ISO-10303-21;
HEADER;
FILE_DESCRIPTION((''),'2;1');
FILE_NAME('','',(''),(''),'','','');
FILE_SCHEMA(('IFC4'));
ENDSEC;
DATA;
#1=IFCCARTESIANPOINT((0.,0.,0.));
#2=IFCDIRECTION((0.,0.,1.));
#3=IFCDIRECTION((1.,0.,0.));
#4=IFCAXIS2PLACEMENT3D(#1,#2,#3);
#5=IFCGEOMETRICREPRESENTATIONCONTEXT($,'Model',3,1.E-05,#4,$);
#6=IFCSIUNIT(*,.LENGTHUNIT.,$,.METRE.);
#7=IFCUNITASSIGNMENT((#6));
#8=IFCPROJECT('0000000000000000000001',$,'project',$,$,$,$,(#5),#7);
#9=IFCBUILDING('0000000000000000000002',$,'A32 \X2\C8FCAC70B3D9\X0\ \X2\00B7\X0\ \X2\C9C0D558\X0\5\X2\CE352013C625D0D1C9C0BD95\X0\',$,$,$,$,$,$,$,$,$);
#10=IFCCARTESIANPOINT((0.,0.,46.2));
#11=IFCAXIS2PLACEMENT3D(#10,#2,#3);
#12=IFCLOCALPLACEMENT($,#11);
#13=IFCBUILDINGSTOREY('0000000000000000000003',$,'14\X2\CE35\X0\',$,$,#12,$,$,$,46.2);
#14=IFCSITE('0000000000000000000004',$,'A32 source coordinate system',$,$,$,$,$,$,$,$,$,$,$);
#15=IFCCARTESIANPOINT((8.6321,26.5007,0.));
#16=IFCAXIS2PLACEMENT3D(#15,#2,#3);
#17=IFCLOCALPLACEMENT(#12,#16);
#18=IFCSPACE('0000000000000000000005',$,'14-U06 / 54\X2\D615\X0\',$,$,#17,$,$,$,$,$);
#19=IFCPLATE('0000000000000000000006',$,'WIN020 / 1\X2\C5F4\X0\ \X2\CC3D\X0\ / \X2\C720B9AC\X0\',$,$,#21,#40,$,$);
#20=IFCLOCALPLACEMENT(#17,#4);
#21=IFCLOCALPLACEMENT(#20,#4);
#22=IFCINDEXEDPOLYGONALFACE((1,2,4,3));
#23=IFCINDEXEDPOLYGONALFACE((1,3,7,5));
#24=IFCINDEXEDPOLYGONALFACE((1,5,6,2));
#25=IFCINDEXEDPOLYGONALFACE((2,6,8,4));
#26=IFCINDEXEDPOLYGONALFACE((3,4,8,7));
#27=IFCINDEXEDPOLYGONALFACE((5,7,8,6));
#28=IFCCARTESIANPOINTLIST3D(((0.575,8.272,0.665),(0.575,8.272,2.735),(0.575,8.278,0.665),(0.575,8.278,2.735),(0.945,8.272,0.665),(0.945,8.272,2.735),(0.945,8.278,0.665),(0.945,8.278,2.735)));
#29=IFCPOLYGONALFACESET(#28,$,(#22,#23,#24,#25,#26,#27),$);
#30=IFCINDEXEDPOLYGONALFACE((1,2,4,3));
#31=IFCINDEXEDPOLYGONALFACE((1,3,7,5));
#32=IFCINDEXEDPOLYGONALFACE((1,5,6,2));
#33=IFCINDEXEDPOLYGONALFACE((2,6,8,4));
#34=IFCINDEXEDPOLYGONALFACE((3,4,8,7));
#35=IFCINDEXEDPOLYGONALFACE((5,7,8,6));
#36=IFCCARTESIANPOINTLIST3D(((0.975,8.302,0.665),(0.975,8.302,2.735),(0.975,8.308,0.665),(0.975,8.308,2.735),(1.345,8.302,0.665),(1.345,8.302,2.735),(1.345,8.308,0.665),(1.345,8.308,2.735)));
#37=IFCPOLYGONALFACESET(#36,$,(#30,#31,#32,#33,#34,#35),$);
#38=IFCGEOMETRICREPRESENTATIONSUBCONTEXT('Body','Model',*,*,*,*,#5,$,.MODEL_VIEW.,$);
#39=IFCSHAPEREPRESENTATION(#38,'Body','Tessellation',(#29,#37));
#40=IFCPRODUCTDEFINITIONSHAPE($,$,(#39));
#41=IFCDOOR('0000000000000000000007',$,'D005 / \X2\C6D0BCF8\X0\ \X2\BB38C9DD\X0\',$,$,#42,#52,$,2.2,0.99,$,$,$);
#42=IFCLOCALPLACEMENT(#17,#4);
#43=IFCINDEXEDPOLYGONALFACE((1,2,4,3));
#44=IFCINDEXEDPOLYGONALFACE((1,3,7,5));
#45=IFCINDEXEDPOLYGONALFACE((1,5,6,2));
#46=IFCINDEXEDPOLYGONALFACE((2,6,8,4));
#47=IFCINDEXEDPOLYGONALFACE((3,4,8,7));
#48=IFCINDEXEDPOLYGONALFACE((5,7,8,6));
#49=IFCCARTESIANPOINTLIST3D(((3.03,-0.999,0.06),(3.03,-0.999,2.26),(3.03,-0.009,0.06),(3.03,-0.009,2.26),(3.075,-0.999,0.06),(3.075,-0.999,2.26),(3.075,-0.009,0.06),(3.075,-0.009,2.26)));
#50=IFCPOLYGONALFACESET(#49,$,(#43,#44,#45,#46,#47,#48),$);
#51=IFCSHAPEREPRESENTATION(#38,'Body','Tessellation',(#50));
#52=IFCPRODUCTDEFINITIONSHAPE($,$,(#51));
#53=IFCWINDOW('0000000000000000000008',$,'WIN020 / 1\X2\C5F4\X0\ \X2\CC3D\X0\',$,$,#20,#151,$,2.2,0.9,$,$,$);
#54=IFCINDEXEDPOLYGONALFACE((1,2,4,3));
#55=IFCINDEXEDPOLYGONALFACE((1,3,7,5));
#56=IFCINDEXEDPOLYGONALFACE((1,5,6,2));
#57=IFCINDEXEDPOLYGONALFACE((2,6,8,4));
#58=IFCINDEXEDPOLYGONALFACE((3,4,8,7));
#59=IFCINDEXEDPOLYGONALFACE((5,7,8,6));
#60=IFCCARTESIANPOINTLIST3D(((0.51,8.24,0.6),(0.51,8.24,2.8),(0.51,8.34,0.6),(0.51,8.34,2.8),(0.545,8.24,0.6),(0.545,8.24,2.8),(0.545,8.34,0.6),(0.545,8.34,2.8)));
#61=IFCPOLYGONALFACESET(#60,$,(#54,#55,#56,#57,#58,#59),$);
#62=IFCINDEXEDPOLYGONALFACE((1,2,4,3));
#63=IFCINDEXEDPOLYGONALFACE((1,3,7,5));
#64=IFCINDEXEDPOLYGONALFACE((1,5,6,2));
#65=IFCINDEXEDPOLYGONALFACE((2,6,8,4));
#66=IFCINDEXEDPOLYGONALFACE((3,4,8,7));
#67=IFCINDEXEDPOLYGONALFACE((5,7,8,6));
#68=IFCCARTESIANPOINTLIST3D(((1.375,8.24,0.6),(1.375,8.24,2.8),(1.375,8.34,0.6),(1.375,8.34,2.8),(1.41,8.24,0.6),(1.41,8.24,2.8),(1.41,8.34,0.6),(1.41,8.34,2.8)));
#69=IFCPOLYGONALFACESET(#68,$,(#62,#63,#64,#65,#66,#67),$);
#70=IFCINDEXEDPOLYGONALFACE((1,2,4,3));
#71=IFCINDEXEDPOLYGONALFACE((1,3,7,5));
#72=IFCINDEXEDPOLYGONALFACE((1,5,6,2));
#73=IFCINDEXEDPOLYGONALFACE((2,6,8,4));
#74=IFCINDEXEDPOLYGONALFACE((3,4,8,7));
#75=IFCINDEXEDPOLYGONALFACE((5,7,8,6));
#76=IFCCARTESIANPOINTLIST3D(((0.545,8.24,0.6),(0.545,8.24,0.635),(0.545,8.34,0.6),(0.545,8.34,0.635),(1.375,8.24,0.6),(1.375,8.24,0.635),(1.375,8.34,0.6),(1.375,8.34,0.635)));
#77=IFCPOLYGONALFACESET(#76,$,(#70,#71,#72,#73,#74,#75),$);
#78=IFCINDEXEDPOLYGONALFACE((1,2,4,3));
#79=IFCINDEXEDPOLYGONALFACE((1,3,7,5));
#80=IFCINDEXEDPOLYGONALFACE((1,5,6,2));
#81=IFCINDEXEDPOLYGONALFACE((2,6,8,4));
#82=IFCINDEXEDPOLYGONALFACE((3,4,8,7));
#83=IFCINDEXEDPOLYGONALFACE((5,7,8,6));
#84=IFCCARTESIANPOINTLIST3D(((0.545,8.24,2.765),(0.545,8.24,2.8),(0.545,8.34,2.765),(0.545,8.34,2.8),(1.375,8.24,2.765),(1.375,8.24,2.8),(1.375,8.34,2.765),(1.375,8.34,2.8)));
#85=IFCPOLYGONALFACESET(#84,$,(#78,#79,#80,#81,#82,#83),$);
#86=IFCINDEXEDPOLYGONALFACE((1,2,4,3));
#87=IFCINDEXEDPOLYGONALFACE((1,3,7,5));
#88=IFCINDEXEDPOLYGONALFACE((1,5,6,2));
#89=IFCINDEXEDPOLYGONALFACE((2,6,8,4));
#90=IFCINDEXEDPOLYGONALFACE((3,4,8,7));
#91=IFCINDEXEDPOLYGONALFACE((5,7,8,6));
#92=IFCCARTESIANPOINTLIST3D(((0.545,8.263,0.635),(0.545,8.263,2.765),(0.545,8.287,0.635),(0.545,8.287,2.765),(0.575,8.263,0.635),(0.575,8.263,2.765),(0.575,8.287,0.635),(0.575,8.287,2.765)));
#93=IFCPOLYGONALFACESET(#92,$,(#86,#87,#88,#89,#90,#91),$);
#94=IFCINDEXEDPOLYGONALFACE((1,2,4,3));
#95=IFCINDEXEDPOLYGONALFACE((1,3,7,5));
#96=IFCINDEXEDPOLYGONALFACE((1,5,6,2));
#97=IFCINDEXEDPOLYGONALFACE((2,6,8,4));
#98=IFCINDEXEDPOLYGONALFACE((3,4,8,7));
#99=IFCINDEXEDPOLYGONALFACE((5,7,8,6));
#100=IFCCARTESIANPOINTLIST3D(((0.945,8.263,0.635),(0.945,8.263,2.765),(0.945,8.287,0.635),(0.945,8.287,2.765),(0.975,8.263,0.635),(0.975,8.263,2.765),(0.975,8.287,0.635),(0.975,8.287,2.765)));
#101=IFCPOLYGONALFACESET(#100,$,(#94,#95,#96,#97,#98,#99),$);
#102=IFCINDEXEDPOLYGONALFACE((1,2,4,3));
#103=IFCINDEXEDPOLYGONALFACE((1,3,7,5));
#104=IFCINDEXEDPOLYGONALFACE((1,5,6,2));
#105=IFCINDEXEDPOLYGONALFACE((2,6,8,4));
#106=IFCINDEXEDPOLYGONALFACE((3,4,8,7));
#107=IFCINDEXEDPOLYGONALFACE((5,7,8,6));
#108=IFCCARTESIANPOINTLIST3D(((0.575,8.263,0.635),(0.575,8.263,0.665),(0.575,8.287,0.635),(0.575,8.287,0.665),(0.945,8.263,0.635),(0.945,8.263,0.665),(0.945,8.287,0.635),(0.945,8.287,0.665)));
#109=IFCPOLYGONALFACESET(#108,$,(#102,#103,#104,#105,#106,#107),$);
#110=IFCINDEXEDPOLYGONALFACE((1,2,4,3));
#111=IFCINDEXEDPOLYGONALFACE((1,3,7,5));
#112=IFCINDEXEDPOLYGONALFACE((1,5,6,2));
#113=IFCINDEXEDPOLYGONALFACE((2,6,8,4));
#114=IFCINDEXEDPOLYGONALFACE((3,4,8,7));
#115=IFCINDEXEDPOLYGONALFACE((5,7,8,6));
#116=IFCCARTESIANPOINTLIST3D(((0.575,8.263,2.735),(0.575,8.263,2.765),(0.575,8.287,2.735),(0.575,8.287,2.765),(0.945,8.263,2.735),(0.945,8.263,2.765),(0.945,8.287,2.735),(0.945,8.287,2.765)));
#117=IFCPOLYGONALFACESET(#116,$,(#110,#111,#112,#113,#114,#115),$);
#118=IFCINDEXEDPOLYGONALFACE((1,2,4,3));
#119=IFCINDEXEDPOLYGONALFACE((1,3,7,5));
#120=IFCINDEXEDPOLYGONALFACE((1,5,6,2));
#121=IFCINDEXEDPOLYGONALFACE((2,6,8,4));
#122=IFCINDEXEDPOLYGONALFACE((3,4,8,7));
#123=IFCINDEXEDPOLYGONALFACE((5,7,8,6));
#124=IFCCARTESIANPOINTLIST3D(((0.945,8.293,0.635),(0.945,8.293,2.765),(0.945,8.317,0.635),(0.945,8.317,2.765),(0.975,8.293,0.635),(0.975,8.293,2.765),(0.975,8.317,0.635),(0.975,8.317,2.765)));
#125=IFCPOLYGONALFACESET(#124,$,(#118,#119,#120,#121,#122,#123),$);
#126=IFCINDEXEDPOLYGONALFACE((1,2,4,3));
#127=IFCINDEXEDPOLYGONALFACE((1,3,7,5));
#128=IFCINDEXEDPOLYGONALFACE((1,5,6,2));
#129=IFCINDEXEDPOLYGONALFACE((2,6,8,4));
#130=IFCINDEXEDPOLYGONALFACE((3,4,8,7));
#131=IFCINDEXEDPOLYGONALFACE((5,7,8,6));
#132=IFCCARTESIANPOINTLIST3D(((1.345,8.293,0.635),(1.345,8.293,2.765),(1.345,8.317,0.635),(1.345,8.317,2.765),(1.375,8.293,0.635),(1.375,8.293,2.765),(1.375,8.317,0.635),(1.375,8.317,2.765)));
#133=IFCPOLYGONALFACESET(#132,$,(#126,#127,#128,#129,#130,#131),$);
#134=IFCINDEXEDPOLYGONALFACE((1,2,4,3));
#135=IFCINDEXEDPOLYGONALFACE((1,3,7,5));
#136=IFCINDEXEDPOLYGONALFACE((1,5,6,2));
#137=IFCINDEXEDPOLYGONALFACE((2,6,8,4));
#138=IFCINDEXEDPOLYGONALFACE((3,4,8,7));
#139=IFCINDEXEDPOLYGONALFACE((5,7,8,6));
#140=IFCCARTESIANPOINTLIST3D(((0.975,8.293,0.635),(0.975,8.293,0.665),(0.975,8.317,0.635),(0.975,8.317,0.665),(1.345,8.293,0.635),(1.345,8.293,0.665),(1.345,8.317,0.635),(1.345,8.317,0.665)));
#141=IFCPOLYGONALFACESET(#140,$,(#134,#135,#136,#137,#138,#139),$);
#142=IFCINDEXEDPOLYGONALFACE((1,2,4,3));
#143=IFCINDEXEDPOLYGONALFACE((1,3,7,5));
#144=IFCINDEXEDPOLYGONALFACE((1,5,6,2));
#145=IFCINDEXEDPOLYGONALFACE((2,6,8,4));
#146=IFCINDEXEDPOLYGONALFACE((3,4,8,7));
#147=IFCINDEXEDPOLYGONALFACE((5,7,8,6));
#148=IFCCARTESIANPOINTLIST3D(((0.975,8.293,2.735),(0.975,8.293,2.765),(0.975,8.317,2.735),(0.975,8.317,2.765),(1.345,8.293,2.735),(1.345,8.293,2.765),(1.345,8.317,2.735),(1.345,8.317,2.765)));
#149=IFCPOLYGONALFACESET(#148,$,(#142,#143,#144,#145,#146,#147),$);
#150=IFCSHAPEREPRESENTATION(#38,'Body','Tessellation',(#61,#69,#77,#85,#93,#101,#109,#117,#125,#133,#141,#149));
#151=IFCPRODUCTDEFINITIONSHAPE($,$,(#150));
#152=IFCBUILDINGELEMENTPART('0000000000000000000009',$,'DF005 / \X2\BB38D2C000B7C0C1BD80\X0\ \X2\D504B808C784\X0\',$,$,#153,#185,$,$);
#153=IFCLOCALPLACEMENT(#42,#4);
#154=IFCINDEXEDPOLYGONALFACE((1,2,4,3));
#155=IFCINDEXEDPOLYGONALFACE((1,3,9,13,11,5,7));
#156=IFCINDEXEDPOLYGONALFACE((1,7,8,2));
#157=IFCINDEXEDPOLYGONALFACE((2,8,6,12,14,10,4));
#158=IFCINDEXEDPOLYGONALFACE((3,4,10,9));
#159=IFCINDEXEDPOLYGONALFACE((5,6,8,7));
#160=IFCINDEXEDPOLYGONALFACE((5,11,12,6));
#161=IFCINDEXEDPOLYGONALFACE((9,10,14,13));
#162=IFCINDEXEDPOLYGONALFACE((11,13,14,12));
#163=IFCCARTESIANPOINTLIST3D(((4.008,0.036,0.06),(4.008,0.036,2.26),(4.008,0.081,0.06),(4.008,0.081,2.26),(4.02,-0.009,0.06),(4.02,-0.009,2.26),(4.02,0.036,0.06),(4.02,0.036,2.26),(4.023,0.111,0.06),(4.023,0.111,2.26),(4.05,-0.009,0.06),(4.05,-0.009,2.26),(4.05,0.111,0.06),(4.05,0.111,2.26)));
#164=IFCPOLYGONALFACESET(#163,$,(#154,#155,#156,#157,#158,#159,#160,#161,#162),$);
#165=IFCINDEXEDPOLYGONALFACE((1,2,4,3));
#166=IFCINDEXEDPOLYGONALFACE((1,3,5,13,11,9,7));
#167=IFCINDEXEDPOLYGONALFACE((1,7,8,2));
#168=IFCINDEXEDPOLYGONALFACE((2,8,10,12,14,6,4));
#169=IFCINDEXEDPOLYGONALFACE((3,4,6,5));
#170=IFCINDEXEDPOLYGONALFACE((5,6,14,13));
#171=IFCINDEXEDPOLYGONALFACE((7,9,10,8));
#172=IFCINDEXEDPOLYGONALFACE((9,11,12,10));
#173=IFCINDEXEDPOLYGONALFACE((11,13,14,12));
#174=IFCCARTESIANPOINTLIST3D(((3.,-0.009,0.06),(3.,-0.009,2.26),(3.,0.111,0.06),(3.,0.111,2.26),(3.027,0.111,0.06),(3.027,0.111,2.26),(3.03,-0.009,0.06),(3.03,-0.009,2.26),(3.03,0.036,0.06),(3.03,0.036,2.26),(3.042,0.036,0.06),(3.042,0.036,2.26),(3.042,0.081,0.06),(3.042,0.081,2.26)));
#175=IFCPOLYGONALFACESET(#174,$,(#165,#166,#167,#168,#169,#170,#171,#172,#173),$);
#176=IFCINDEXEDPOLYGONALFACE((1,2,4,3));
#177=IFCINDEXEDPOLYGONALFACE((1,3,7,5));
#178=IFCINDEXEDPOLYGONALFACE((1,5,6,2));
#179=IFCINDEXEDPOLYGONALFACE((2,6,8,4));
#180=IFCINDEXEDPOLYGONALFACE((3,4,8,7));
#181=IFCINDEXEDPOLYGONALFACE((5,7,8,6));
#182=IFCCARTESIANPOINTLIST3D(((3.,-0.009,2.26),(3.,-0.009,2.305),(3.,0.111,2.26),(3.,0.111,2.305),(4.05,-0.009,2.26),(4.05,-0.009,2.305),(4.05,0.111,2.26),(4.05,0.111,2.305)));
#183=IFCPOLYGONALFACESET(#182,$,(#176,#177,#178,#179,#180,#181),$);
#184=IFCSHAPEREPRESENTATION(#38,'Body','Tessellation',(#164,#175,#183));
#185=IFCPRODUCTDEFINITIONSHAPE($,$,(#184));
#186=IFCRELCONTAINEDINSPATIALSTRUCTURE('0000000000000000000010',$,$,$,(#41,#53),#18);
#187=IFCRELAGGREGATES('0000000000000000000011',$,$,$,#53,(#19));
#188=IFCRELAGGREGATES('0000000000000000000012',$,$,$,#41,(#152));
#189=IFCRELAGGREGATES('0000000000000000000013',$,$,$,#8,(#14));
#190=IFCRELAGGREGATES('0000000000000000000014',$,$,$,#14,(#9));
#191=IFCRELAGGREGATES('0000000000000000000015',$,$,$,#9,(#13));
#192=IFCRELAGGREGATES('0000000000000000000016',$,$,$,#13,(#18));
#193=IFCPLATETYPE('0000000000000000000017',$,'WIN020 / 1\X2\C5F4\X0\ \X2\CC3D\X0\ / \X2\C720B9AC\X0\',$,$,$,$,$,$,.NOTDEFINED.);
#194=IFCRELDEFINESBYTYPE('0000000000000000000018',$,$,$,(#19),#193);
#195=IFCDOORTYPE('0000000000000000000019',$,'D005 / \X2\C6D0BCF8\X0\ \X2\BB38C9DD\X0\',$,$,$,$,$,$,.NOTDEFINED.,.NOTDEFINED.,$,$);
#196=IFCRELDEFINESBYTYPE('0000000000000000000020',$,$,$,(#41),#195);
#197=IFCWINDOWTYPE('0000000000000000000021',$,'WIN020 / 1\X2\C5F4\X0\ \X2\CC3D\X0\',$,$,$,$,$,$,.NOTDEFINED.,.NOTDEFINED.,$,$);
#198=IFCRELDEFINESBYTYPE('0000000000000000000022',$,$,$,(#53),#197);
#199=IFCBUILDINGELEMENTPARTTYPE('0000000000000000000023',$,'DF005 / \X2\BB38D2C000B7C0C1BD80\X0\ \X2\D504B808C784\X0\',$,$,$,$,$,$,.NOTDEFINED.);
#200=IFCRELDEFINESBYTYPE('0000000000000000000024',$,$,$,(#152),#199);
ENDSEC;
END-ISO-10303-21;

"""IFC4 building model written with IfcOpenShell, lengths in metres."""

from ifc_helpers import new_model, si_unit, frame, origin, origin_with_axes, place, context, subcontext, project, spatial, polyline, outline, extrude, source, transform, mapped, type_object, type_shapes, element, aggregate, save


model = new_model("IFC4")

# Units and contexts
model_context = context("Model", 3, precision=1e-05, world=origin_with_axes())
body_context = subcontext(model_context, "Body", "Model", "MODEL_VIEW")
ifc_project = project(units=[si_unit("LENGTHUNIT", "METRE")], contexts=[model_context])

# Plate
storey_placement = place(None, frame((0.0, 0.0, 46.2), z_axis=(0.0, 0.0, 1.0), x_axis=(1.0, 0.0, 0.0)))
space_1_placement = place(storey_placement, frame((8.6321, 26.5007, 0.0), z_axis=(0.0, 0.0, 1.0), x_axis=(1.0, 0.0, 0.0)))
plate_type_1 = type_object("IfcPlateType", Name="WIN020 / 1열 창 / 유리", PredefinedType="NOTDEFINED")
shared_shape_1 = source(origin(), body_context, "Body", "SweptSolid", [
    extrude(outline(polyline([(0.575, 8.272), (0.575, 8.278), (0.945, 8.278), (0.945, 8.272), (0.575, 8.272)])), frame((0.0, 0.0, 0.665)), (0.0, 0.0, 1.0), 2.07),
    extrude(outline(polyline([(0.975, 8.302), (0.975, 8.308), (1.345, 8.308), (1.345, 8.302), (0.975, 8.302)])), frame((0.0, 0.0, 0.665)), (0.0, 0.0, 1.0), 2.07),
])
type_shapes(plate_type_1, [shared_shape_1])
window_1_placement = place(space_1_placement, origin_with_axes())
plate_1_placement = place(window_1_placement, origin_with_axes())
plate_1 = element("IfcPlate", 1, at=plate_1_placement, type_object=plate_type_1, Name="WIN020 / 1열 창 / 유리", context=body_context, shape_type="MappedRepresentation", body=[
    mapped(shared_shape_1, transform((0.0, 0.0, 0.0), scale=1.0)),
])

# Site, building, storey, space
site = spatial("IfcSite", under=ifc_project, Name="A32 source coordinate system")
building = spatial("IfcBuilding", under=site, Name="A32 주거동 · 지하5층–옥탑지붕")
storey = spatial("IfcBuildingStorey", under=building, at=storey_placement, Name="14층", Elevation=46.2)
space_1 = spatial("IfcSpace", under=storey, at=space_1_placement, Name="14-U06 / 54형")

# Door
door_type_1 = type_object("IfcDoorType", Name="D005 / 원본 문짝", OperationType="NOTDEFINED", PredefinedType="NOTDEFINED")
shared_shape_2 = source(origin(), body_context, "Body", "SweptSolid", [
    extrude(outline(polyline([(3.075, -0.999), (3.03, -0.999), (3.03, -0.009), (3.075, -0.009), (3.075, -0.999)])), frame((0.0, 0.0, 0.06)), (0.0, 0.0, 1.0), 2.2),
])
type_shapes(door_type_1, [shared_shape_2])
door_1_placement = place(space_1_placement, origin_with_axes())
door_1 = element("IfcDoor", 2, at=door_1_placement, inside=space_1, type_object=door_type_1, Name="D005 / 원본 문짝", OverallHeight=2.2, OverallWidth=0.99, context=body_context, shape_type="MappedRepresentation", body=[
    mapped(shared_shape_2, transform((0.0, 0.0, 0.0), scale=1.0)),
])

# Window
window_type_1 = type_object("IfcWindowType", Name="WIN020 / 1열 창", PartitioningType="NOTDEFINED", PredefinedType="NOTDEFINED")
shared_shape_3 = source(origin(), body_context, "Body", "SweptSolid", [
    extrude(outline(polyline([(0.51, 8.24), (0.51, 8.34), (0.545, 8.34), (0.545, 8.24), (0.51, 8.24)])), frame((0.0, 0.0, 0.6)), (0.0, 0.0, 1.0), 2.2),
    extrude(outline(polyline([(1.375, 8.24), (1.375, 8.34), (1.41, 8.34), (1.41, 8.24), (1.375, 8.24)])), frame((0.0, 0.0, 0.6)), (0.0, 0.0, 1.0), 2.2),
    extrude(outline(polyline([(0.545, 8.24), (0.545, 8.34), (1.375, 8.34), (1.375, 8.24), (0.545, 8.24)])), frame((0.0, 0.0, 0.6)), (0.0, 0.0, 1.0), 0.035),
    extrude(outline(polyline([(0.545, 8.24), (0.545, 8.34), (1.375, 8.34), (1.375, 8.24), (0.545, 8.24)])), frame((0.0, 0.0, 2.765)), (0.0, 0.0, 1.0), 0.035),
    extrude(outline(polyline([(0.545, 8.263), (0.545, 8.287), (0.575, 8.287), (0.575, 8.263), (0.545, 8.263)])), frame((0.0, 0.0, 0.635)), (0.0, 0.0, 1.0), 2.13),
    extrude(outline(polyline([(0.945, 8.263), (0.945, 8.287), (0.975, 8.287), (0.975, 8.263), (0.945, 8.263)])), frame((0.0, 0.0, 0.635)), (0.0, 0.0, 1.0), 2.13),
    extrude(outline(polyline([(0.575, 8.263), (0.575, 8.287), (0.945, 8.287), (0.945, 8.263), (0.575, 8.263)])), frame((0.0, 0.0, 0.635)), (0.0, 0.0, 1.0), 0.03),
    extrude(outline(polyline([(0.575, 8.263), (0.575, 8.287), (0.945, 8.287), (0.945, 8.263), (0.575, 8.263)])), frame((0.0, 0.0, 2.735)), (0.0, 0.0, 1.0), 0.03),
    extrude(outline(polyline([(0.945, 8.293), (0.945, 8.317), (0.975, 8.317), (0.975, 8.293), (0.945, 8.293)])), frame((0.0, 0.0, 0.635)), (0.0, 0.0, 1.0), 2.13),
    extrude(outline(polyline([(1.345, 8.293), (1.345, 8.317), (1.375, 8.317), (1.375, 8.293), (1.345, 8.293)])), frame((0.0, 0.0, 0.635)), (0.0, 0.0, 1.0), 2.13),
    extrude(outline(polyline([(0.975, 8.293), (0.975, 8.317), (1.345, 8.317), (1.345, 8.293), (0.975, 8.293)])), frame((0.0, 0.0, 0.635)), (0.0, 0.0, 1.0), 0.03),
    extrude(outline(polyline([(0.975, 8.293), (0.975, 8.317), (1.345, 8.317), (1.345, 8.293), (0.975, 8.293)])), frame((0.0, 0.0, 2.735)), (0.0, 0.0, 1.0), 0.03),
])
type_shapes(window_type_1, [shared_shape_3])
window_1 = element("IfcWindow", 3, at=window_1_placement, inside=space_1, type_object=window_type_1, Name="WIN020 / 1열 창", OverallHeight=2.2, OverallWidth=0.9, context=body_context, shape_type="MappedRepresentation", body=[
    mapped(shared_shape_3, transform((0.0, 0.0, 0.0), scale=1.0)),
])
aggregate(window_1, [plate_1])

# Building element part
building_element_part_type_1 = type_object("IfcBuildingElementPartType", Name="DF005 / 문틀·상부 프레임", PredefinedType="NOTDEFINED")
shared_shape_4 = source(origin(), body_context, "Body", "SweptSolid", [
    extrude(outline(polyline([(4.02, -0.009), (4.02, 0.036), (4.008, 0.036), (4.008, 0.081), (4.023, 0.111), (4.05, 0.111), (4.05, -0.009), (4.02, -0.009)])), frame((0.0, 0.0, 0.06)), (0.0, 0.0, 1.0), 2.2),
    extrude(outline(polyline([(3.0, 0.111), (3.027, 0.111), (3.042, 0.081), (3.042, 0.036), (3.03, 0.036), (3.03, -0.009), (3.0, -0.009), (3.0, 0.111)])), frame((0.0, 0.0, 0.06)), (0.0, 0.0, 1.0), 2.2),
    extrude(outline(polyline([(3.0, -0.009), (3.0, 0.111), (4.05, 0.111), (4.05, -0.009), (3.0, -0.009)])), frame((0.0, 0.0, 2.26)), (0.0, 0.0, 1.0), 0.045),
])
type_shapes(building_element_part_type_1, [shared_shape_4])
building_element_part_1_placement = place(door_1_placement, origin_with_axes())
building_element_part_1 = element("IfcBuildingElementPart", 4, at=building_element_part_1_placement, type_object=building_element_part_type_1, Name="DF005 / 문틀·상부 프레임", context=body_context, shape_type="MappedRepresentation", body=[
    mapped(shared_shape_4, transform((0.0, 0.0, 0.0), scale=1.0)),
])
aggregate(door_1, [building_element_part_1])

save(model, "model.ifc")
